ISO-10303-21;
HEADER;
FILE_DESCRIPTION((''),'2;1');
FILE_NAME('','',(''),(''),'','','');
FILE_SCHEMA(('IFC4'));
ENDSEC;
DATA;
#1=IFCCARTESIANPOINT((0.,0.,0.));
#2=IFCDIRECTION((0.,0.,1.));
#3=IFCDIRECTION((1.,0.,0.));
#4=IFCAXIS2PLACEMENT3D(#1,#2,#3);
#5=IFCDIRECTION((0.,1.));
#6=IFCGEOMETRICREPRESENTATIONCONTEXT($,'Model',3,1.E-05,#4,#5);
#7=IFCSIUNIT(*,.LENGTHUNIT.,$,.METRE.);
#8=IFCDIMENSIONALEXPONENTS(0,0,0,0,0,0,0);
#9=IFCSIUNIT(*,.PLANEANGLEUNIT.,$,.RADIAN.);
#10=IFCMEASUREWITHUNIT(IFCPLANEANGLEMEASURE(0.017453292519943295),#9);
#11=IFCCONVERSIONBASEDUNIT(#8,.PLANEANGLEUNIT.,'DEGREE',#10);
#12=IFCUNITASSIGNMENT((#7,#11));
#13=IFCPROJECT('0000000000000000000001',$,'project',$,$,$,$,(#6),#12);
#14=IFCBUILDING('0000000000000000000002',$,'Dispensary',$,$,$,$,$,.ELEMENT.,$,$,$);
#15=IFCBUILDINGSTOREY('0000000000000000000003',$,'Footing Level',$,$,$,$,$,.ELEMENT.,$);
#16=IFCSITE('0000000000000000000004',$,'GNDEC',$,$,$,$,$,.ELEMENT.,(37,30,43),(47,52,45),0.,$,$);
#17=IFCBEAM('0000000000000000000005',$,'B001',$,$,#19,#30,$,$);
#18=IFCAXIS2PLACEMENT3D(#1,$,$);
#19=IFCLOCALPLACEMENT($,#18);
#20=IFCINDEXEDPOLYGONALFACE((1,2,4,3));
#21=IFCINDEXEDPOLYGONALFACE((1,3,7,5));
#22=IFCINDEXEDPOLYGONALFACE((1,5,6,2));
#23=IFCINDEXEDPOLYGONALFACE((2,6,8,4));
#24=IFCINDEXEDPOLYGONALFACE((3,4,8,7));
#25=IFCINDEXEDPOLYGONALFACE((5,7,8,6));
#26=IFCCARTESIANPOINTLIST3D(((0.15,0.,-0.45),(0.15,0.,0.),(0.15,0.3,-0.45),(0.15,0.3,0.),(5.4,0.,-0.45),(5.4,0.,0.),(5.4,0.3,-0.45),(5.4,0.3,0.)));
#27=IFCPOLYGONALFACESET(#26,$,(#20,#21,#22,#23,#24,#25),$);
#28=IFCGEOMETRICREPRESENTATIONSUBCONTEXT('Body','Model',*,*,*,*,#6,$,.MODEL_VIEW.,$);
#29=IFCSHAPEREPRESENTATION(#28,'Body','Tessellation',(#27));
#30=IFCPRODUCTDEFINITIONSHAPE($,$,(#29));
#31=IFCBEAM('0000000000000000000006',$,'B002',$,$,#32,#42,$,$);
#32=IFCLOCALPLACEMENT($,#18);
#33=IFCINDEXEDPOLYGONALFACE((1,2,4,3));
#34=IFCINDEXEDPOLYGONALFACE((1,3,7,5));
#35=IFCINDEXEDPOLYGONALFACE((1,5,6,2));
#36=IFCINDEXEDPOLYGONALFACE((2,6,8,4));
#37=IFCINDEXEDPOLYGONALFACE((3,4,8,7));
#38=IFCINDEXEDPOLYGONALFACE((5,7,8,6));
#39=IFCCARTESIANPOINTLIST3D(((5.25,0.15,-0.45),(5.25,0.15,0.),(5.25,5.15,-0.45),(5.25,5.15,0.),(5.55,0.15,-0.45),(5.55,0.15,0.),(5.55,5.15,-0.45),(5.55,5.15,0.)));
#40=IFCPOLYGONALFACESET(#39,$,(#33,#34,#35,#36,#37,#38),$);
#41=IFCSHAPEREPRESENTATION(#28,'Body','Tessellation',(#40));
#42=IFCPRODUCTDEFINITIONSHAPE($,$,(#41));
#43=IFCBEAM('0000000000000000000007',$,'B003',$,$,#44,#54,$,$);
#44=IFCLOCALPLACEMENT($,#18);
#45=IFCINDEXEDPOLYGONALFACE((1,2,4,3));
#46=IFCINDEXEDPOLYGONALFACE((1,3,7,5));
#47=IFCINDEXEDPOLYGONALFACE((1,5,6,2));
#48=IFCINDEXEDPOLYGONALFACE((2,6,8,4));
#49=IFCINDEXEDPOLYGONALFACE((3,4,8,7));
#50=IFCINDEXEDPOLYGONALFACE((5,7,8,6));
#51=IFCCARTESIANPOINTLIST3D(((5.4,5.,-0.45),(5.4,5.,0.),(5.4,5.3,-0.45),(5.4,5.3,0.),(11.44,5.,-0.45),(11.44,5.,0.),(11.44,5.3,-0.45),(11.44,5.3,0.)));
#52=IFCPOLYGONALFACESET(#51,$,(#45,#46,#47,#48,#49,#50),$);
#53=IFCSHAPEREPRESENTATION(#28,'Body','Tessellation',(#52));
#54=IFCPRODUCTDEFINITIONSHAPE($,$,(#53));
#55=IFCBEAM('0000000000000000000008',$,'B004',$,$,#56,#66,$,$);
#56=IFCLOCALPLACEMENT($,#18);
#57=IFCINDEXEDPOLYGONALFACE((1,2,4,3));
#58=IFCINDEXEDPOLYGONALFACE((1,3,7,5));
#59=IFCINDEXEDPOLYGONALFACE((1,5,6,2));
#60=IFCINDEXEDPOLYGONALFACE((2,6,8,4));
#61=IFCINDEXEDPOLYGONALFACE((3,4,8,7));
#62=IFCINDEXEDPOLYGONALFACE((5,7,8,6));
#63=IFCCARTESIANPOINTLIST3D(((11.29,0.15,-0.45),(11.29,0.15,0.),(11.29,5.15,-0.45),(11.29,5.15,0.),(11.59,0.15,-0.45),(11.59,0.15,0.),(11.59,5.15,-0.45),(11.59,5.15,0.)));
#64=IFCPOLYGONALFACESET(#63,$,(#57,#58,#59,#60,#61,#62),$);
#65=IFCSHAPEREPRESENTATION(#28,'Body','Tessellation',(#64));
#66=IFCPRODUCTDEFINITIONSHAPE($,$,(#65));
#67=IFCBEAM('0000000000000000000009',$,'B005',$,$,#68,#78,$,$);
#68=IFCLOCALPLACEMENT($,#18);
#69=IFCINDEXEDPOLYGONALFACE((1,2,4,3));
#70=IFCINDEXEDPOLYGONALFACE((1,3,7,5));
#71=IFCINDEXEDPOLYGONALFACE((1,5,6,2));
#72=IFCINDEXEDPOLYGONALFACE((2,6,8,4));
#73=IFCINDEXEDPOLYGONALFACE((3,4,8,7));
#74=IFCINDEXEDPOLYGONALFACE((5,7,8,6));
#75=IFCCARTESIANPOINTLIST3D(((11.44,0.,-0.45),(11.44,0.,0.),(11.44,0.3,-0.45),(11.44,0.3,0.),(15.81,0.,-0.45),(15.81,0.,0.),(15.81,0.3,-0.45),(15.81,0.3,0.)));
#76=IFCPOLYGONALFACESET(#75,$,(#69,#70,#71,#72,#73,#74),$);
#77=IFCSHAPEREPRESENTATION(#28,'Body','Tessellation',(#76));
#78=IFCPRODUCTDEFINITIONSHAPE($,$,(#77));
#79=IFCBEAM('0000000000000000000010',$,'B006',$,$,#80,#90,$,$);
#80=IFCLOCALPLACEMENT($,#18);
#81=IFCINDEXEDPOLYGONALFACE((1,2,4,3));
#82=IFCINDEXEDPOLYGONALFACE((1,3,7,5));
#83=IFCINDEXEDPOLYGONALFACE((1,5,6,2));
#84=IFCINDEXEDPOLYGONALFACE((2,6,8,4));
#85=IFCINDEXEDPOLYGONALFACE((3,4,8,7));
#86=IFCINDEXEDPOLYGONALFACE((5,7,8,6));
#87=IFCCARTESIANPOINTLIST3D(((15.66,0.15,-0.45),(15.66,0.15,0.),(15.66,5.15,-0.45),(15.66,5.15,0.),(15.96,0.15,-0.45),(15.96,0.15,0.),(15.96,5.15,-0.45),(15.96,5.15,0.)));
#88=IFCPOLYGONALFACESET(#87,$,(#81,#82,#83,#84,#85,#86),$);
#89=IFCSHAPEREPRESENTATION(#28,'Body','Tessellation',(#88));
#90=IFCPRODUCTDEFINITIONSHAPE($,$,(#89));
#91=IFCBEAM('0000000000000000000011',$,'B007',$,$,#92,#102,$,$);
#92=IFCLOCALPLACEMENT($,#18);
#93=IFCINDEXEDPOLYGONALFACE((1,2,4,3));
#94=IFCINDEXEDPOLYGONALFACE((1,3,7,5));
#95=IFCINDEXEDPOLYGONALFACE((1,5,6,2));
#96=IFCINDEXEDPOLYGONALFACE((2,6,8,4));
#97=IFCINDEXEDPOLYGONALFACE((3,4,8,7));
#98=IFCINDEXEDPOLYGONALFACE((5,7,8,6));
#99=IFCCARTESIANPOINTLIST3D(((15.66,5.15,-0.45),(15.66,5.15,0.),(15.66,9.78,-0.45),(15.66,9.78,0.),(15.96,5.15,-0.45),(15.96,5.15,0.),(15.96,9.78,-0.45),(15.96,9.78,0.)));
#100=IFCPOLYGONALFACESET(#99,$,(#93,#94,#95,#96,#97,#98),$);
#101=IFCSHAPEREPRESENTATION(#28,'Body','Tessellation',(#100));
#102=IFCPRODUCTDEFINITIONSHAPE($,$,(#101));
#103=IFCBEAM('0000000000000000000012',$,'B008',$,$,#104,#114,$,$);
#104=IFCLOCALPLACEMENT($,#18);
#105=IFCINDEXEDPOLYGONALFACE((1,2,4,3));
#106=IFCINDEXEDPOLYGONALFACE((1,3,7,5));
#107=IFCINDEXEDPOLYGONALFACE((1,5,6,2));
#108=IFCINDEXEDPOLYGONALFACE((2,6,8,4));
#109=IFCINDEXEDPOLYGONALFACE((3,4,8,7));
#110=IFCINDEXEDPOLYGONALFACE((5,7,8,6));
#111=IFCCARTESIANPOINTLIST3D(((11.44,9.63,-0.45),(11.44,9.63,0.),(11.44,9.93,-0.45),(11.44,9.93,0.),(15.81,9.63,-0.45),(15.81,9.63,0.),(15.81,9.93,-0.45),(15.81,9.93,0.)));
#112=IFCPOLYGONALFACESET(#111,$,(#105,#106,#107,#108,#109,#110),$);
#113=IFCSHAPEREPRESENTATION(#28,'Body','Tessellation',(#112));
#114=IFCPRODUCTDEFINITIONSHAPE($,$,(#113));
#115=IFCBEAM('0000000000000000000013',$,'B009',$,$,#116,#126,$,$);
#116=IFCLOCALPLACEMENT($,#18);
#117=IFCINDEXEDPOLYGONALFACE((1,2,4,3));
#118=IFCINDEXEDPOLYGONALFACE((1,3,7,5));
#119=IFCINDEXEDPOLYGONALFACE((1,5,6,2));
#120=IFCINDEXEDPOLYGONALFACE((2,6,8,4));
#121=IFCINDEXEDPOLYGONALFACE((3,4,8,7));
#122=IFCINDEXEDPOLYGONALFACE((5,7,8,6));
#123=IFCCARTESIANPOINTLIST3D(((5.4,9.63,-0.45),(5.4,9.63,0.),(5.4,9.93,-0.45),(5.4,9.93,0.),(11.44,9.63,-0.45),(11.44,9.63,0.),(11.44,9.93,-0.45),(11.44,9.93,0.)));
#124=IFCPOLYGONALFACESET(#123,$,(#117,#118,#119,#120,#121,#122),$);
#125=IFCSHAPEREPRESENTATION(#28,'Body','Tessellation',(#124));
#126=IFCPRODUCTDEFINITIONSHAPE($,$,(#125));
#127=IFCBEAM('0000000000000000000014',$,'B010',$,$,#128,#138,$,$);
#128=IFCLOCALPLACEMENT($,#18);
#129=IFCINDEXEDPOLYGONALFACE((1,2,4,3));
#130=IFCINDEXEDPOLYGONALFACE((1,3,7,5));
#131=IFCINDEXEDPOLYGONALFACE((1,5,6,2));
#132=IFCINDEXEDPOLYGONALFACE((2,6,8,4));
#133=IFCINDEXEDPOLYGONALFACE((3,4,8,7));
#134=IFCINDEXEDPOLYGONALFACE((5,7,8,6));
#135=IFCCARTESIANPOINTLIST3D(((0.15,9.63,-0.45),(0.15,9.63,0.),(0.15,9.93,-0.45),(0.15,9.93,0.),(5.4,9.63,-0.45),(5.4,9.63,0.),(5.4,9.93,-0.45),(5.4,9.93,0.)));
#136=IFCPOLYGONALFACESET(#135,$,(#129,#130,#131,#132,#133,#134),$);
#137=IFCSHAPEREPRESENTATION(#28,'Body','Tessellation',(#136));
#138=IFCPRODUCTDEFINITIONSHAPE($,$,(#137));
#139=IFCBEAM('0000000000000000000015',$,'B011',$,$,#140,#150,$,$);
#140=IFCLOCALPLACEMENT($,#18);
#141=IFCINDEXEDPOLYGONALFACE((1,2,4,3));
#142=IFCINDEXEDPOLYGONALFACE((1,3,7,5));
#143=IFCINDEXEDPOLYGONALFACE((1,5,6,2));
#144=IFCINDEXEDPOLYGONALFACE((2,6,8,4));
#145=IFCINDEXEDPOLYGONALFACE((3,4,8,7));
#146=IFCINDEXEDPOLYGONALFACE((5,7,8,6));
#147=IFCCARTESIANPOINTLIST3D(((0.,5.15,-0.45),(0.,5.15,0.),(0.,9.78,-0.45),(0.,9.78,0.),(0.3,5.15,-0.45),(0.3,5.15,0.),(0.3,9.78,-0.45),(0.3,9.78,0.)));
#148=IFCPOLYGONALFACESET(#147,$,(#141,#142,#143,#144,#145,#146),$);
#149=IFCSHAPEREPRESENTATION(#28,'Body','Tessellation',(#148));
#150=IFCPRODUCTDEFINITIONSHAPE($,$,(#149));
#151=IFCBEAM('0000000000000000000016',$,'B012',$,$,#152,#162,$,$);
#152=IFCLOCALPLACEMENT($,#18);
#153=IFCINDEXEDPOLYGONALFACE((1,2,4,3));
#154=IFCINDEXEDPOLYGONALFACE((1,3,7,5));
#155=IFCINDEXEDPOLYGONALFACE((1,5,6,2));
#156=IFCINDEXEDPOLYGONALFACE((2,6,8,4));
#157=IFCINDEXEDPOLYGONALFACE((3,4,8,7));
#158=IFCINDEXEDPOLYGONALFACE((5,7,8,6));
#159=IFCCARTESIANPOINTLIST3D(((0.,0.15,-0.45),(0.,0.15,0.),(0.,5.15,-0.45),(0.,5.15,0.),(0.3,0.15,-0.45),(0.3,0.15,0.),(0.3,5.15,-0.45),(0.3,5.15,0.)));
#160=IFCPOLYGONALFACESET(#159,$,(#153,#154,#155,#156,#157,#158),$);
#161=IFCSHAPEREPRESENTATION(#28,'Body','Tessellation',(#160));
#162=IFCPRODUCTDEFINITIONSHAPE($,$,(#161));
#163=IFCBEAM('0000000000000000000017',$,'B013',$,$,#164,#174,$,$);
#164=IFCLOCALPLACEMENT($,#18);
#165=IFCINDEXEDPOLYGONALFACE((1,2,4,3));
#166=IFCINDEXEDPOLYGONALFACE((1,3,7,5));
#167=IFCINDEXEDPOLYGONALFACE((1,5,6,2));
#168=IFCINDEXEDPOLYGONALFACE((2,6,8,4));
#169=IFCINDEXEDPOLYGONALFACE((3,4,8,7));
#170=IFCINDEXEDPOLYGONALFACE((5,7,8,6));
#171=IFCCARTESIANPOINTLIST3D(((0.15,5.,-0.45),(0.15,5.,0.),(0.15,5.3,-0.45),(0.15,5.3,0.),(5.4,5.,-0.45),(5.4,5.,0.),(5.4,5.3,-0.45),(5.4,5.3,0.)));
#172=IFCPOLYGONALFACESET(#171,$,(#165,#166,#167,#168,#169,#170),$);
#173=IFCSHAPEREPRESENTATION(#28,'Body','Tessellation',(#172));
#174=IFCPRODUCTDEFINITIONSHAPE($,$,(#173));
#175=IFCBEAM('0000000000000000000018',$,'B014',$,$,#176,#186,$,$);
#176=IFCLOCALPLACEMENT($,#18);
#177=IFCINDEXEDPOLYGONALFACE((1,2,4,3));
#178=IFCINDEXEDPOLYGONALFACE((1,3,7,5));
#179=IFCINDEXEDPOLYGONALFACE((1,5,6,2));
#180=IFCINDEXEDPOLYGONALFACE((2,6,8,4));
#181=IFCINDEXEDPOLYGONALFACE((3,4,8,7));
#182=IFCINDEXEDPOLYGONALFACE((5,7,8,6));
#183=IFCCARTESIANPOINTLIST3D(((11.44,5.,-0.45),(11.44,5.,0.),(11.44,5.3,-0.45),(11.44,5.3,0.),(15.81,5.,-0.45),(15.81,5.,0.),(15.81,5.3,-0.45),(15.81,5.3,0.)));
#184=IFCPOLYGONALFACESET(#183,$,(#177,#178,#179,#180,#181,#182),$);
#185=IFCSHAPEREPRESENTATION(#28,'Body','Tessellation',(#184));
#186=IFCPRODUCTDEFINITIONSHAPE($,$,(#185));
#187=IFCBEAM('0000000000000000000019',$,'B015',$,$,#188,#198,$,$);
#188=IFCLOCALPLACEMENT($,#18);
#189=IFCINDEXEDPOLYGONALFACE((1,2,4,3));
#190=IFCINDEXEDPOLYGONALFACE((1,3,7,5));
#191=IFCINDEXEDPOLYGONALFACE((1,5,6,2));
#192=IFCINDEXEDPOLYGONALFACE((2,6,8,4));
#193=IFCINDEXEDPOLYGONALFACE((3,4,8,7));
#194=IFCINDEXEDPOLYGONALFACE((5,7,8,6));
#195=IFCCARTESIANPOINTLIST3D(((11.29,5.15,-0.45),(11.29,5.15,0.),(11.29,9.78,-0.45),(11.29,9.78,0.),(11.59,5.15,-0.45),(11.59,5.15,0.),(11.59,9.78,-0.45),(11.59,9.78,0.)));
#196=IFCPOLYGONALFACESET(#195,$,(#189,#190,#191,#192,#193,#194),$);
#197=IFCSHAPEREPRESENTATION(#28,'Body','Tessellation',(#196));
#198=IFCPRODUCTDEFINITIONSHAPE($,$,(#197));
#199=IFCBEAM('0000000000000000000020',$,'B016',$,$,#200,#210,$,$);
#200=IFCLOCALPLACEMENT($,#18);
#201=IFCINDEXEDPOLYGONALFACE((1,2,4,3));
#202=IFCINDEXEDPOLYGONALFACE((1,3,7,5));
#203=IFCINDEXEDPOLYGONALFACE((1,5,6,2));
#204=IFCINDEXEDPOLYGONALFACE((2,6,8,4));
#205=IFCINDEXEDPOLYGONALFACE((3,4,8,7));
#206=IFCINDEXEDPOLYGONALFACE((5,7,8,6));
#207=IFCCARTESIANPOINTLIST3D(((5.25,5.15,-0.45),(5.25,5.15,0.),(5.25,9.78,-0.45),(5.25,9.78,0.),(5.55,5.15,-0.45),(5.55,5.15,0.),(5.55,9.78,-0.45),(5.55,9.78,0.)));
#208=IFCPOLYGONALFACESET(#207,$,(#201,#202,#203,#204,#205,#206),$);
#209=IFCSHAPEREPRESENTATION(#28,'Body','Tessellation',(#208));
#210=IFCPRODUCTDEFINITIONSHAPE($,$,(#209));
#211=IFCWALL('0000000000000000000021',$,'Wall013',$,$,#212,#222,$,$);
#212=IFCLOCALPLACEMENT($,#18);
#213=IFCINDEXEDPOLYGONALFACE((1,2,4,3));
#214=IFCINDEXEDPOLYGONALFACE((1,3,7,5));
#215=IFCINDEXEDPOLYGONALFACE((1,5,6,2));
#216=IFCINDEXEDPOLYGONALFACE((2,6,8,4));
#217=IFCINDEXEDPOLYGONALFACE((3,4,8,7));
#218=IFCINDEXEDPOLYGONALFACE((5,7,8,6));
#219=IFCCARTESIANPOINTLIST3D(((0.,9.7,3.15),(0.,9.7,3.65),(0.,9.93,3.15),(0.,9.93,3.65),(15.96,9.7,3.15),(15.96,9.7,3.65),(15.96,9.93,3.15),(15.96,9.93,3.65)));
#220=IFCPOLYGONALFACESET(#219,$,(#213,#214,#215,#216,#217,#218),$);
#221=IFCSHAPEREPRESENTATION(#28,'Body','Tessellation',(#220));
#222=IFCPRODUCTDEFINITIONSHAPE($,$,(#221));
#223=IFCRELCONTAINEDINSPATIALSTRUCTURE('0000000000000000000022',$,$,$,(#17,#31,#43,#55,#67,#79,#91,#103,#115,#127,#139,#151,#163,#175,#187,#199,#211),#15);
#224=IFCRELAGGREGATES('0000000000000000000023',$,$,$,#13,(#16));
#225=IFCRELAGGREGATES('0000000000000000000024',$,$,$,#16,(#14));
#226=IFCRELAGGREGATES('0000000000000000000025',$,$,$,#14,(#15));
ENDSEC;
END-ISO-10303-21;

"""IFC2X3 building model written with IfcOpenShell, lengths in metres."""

from ifc_helpers import new_model, entity, si_unit, converted_unit, direction, frame, frame_2d, origin_with_axes, place, context, subcontext, project, spatial, rectangle, extrude, element, save


model = new_model("IFC2X3")

# Units and contexts
model_context = context("Model", 3, precision=1e-05, world=origin_with_axes(), true_north=direction((0.0, 1.0)))
body_context = subcontext(model_context, "Body", "Model", "MODEL_VIEW")
ifc_project = project(units=[si_unit("LENGTHUNIT", "METRE"), converted_unit("PLANEANGLEUNIT", "DEGREE", entity("IfcPlaneAngleMeasure", 0.017453292519943295), si_unit("PLANEANGLEUNIT", "RADIAN"), dimensions=[0, 0, 0, 0, 0, 0, 0])], contexts=[model_context])

# Site, building, storey
site = spatial("IfcSite", under=ifc_project, Name="GNDEC", CompositionType="ELEMENT", RefLatitude=(37, 30, 43), RefLongitude=(47, 52, 45), RefElevation=0.0)
building = spatial("IfcBuilding", under=site, Name="Dispensary", CompositionType="ELEMENT")
storey = spatial("IfcBuildingStorey", under=building, Name="Footing Level", CompositionType="ELEMENT")

# Beams
placement = place(None, origin_with_axes())
element("IfcBeam", 1, at=placement, inside=storey, Name="B001", context=body_context, shape_type="SweptSolid", body=[
    extrude(rectangle(XDim=0.3, YDim=0.45, at=frame_2d((0.0, 0.0), x_axis=(0.0, 1.0))), frame((0.15, 0.15, -0.225), z_axis=(1.0, 0.0, 0.0), x_axis=(0.0, 0.0, -1.0)), (0.0, 0.0, 1.0), 5.25),
])
element("IfcBeam", 2, at=placement, inside=storey, Name="B002", context=body_context, shape_type="SweptSolid", body=[
    extrude(rectangle(XDim=0.3, YDim=0.45, at=frame_2d((0.0, 0.0), x_axis=(0.0, 1.0))), frame((5.4, 0.15, -0.225), z_axis=(0.0, 1.0, 0.0), x_axis=(0.0, 0.0, -1.0)), (0.0, 0.0, 1.0), 5.0),
])
element("IfcBeam", 3, at=placement, inside=storey, Name="B003", context=body_context, shape_type="SweptSolid", body=[
    extrude(rectangle(XDim=0.3, YDim=0.45, at=frame_2d((0.0, 0.0), x_axis=(0.0, 1.0))), frame((5.4, 5.15, -0.225), z_axis=(1.0, 0.0, 0.0), x_axis=(0.0, 0.0, -1.0)), (0.0, 0.0, 1.0), 6.04),
])
element("IfcBeam", 4, at=placement, inside=storey, Name="B004", context=body_context, shape_type="SweptSolid", body=[
    extrude(rectangle(XDim=0.3, YDim=0.45, at=frame_2d((0.0, 0.0), x_axis=(0.0, 1.0))), frame((11.44, 5.15, -0.225), z_axis=(0.0, -1.0, 0.0), x_axis=(0.0, 0.0, -1.0)), (0.0, 0.0, 1.0), 5.0),
])
element("IfcBeam", 5, at=placement, inside=storey, Name="B005", context=body_context, shape_type="SweptSolid", body=[
    extrude(rectangle(XDim=0.3, YDim=0.45, at=frame_2d((0.0, 0.0), x_axis=(0.0, 1.0))), frame((11.44, 0.15, -0.225), z_axis=(1.0, 0.0, 0.0), x_axis=(0.0, 0.0, -1.0)), (0.0, 0.0, 1.0), 4.37),
])
element("IfcBeam", 6, at=placement, inside=storey, Name="B006", context=body_context, shape_type="SweptSolid", body=[
    extrude(rectangle(XDim=0.3, YDim=0.45, at=frame_2d((0.0, 0.0), x_axis=(0.0, 1.0))), frame((15.81, 0.15, -0.225), z_axis=(0.0, 1.0, 0.0), x_axis=(0.0, 0.0, -1.0)), (0.0, 0.0, 1.0), 5.0),
])
element("IfcBeam", 7, at=placement, inside=storey, Name="B007", context=body_context, shape_type="SweptSolid", body=[
    extrude(rectangle(XDim=0.3, YDim=0.45, at=frame_2d((0.0, 0.0), x_axis=(0.0, 1.0))), frame((15.81, 5.15, -0.225), z_axis=(0.0, 1.0, 0.0), x_axis=(0.0, 0.0, -1.0)), (0.0, 0.0, 1.0), 4.63),
])
element("IfcBeam", 8, at=placement, inside=storey, Name="B008", context=body_context, shape_type="SweptSolid", body=[
    extrude(rectangle(XDim=0.3, YDim=0.45, at=frame_2d((0.0, 0.0), x_axis=(0.0, 1.0))), frame((15.81, 9.78, -0.225), z_axis=(-1.0, 0.0, 0.0), x_axis=(0.0, 0.0, -1.0)), (0.0, 0.0, 1.0), 4.37),
])
element("IfcBeam", 9, at=placement, inside=storey, Name="B009", context=body_context, shape_type="SweptSolid", body=[
    extrude(rectangle(XDim=0.3, YDim=0.45, at=frame_2d((0.0, 0.0), x_axis=(0.0, 1.0))), frame((11.44, 9.78, -0.225), z_axis=(-1.0, 0.0, 0.0), x_axis=(0.0, 0.0, -1.0)), (0.0, 0.0, 1.0), 6.04),
])
element("IfcBeam", 10, at=placement, inside=storey, Name="B010", context=body_context, shape_type="SweptSolid", body=[
    extrude(rectangle(XDim=0.3, YDim=0.45, at=frame_2d((0.0, 0.0), x_axis=(0.0, 1.0))), frame((5.4, 9.78, -0.225), z_axis=(-1.0, 0.0, 0.0), x_axis=(0.0, 0.0, -1.0)), (0.0, 0.0, 1.0), 5.25),
])
element("IfcBeam", 11, at=placement, inside=storey, Name="B011", context=body_context, shape_type="SweptSolid", body=[
    extrude(rectangle(XDim=0.3, YDim=0.45, at=frame_2d((0.0, 0.0), x_axis=(0.0, 1.0))), frame((0.15, 9.78, -0.225), z_axis=(0.0, -1.0, 0.0), x_axis=(0.0, 0.0, -1.0)), (0.0, 0.0, 1.0), 4.63),
])
element("IfcBeam", 12, at=placement, inside=storey, Name="B012", context=body_context, shape_type="SweptSolid", body=[
    extrude(rectangle(XDim=0.3, YDim=0.45, at=frame_2d((0.0, 0.0), x_axis=(0.0, 1.0))), frame((0.15, 5.15, -0.225), z_axis=(0.0, -1.0, 0.0), x_axis=(0.0, 0.0, -1.0)), (0.0, 0.0, 1.0), 5.0),
])
element("IfcBeam", 13, at=placement, inside=storey, Name="B013", context=body_context, shape_type="SweptSolid", body=[
    extrude(rectangle(XDim=0.3, YDim=0.45, at=frame_2d((0.0, 0.0), x_axis=(0.0, 1.0))), frame((0.15, 5.15, -0.225), z_axis=(1.0, 0.0, 0.0), x_axis=(0.0, 0.0, -1.0)), (0.0, 0.0, 1.0), 5.25),
])
element("IfcBeam", 14, at=placement, inside=storey, Name="B014", context=body_context, shape_type="SweptSolid", body=[
    extrude(rectangle(XDim=0.3, YDim=0.45, at=frame_2d((0.0, 0.0), x_axis=(0.0, 1.0))), frame((15.81, 5.15, -0.225), z_axis=(-1.0, 0.0, 0.0), x_axis=(0.0, 0.0, -1.0)), (0.0, 0.0, 1.0), 4.37),
])
element("IfcBeam", 15, at=placement, inside=storey, Name="B015", context=body_context, shape_type="SweptSolid", body=[
    extrude(rectangle(XDim=0.3, YDim=0.45, at=frame_2d((0.0, 0.0), x_axis=(0.0, 1.0))), frame((11.44, 5.15, -0.225), z_axis=(0.0, 1.0, 0.0), x_axis=(0.0, 0.0, -1.0)), (0.0, 0.0, 1.0), 4.63),
])
element("IfcBeam", 16, at=placement, inside=storey, Name="B016", context=body_context, shape_type="SweptSolid", body=[
    extrude(rectangle(XDim=0.3, YDim=0.45, at=frame_2d((0.0, 0.0), x_axis=(0.0, 1.0))), frame((5.4, 5.15, -0.225), z_axis=(0.0, 1.0, 0.0), x_axis=(0.0, 0.0, -1.0)), (0.0, 0.0, 1.0), 4.63),
])

# Wall
element("IfcWall", 17, at=placement, inside=storey, Name="Wall013", context=body_context, shape_type="SweptSolid", body=[
    extrude(rectangle(XDim=15.96, YDim=0.23, at=frame_2d((0.0, 0.0), x_axis=(-1.0, 0.0))), frame((7.98, 9.815, 3.15), z_axis=(0.0, 0.0, 1.0), x_axis=(1.0, 0.0, 0.0)), (0.0, 0.0, 1.0), 0.5),
])

save(model, "model.ifc")
